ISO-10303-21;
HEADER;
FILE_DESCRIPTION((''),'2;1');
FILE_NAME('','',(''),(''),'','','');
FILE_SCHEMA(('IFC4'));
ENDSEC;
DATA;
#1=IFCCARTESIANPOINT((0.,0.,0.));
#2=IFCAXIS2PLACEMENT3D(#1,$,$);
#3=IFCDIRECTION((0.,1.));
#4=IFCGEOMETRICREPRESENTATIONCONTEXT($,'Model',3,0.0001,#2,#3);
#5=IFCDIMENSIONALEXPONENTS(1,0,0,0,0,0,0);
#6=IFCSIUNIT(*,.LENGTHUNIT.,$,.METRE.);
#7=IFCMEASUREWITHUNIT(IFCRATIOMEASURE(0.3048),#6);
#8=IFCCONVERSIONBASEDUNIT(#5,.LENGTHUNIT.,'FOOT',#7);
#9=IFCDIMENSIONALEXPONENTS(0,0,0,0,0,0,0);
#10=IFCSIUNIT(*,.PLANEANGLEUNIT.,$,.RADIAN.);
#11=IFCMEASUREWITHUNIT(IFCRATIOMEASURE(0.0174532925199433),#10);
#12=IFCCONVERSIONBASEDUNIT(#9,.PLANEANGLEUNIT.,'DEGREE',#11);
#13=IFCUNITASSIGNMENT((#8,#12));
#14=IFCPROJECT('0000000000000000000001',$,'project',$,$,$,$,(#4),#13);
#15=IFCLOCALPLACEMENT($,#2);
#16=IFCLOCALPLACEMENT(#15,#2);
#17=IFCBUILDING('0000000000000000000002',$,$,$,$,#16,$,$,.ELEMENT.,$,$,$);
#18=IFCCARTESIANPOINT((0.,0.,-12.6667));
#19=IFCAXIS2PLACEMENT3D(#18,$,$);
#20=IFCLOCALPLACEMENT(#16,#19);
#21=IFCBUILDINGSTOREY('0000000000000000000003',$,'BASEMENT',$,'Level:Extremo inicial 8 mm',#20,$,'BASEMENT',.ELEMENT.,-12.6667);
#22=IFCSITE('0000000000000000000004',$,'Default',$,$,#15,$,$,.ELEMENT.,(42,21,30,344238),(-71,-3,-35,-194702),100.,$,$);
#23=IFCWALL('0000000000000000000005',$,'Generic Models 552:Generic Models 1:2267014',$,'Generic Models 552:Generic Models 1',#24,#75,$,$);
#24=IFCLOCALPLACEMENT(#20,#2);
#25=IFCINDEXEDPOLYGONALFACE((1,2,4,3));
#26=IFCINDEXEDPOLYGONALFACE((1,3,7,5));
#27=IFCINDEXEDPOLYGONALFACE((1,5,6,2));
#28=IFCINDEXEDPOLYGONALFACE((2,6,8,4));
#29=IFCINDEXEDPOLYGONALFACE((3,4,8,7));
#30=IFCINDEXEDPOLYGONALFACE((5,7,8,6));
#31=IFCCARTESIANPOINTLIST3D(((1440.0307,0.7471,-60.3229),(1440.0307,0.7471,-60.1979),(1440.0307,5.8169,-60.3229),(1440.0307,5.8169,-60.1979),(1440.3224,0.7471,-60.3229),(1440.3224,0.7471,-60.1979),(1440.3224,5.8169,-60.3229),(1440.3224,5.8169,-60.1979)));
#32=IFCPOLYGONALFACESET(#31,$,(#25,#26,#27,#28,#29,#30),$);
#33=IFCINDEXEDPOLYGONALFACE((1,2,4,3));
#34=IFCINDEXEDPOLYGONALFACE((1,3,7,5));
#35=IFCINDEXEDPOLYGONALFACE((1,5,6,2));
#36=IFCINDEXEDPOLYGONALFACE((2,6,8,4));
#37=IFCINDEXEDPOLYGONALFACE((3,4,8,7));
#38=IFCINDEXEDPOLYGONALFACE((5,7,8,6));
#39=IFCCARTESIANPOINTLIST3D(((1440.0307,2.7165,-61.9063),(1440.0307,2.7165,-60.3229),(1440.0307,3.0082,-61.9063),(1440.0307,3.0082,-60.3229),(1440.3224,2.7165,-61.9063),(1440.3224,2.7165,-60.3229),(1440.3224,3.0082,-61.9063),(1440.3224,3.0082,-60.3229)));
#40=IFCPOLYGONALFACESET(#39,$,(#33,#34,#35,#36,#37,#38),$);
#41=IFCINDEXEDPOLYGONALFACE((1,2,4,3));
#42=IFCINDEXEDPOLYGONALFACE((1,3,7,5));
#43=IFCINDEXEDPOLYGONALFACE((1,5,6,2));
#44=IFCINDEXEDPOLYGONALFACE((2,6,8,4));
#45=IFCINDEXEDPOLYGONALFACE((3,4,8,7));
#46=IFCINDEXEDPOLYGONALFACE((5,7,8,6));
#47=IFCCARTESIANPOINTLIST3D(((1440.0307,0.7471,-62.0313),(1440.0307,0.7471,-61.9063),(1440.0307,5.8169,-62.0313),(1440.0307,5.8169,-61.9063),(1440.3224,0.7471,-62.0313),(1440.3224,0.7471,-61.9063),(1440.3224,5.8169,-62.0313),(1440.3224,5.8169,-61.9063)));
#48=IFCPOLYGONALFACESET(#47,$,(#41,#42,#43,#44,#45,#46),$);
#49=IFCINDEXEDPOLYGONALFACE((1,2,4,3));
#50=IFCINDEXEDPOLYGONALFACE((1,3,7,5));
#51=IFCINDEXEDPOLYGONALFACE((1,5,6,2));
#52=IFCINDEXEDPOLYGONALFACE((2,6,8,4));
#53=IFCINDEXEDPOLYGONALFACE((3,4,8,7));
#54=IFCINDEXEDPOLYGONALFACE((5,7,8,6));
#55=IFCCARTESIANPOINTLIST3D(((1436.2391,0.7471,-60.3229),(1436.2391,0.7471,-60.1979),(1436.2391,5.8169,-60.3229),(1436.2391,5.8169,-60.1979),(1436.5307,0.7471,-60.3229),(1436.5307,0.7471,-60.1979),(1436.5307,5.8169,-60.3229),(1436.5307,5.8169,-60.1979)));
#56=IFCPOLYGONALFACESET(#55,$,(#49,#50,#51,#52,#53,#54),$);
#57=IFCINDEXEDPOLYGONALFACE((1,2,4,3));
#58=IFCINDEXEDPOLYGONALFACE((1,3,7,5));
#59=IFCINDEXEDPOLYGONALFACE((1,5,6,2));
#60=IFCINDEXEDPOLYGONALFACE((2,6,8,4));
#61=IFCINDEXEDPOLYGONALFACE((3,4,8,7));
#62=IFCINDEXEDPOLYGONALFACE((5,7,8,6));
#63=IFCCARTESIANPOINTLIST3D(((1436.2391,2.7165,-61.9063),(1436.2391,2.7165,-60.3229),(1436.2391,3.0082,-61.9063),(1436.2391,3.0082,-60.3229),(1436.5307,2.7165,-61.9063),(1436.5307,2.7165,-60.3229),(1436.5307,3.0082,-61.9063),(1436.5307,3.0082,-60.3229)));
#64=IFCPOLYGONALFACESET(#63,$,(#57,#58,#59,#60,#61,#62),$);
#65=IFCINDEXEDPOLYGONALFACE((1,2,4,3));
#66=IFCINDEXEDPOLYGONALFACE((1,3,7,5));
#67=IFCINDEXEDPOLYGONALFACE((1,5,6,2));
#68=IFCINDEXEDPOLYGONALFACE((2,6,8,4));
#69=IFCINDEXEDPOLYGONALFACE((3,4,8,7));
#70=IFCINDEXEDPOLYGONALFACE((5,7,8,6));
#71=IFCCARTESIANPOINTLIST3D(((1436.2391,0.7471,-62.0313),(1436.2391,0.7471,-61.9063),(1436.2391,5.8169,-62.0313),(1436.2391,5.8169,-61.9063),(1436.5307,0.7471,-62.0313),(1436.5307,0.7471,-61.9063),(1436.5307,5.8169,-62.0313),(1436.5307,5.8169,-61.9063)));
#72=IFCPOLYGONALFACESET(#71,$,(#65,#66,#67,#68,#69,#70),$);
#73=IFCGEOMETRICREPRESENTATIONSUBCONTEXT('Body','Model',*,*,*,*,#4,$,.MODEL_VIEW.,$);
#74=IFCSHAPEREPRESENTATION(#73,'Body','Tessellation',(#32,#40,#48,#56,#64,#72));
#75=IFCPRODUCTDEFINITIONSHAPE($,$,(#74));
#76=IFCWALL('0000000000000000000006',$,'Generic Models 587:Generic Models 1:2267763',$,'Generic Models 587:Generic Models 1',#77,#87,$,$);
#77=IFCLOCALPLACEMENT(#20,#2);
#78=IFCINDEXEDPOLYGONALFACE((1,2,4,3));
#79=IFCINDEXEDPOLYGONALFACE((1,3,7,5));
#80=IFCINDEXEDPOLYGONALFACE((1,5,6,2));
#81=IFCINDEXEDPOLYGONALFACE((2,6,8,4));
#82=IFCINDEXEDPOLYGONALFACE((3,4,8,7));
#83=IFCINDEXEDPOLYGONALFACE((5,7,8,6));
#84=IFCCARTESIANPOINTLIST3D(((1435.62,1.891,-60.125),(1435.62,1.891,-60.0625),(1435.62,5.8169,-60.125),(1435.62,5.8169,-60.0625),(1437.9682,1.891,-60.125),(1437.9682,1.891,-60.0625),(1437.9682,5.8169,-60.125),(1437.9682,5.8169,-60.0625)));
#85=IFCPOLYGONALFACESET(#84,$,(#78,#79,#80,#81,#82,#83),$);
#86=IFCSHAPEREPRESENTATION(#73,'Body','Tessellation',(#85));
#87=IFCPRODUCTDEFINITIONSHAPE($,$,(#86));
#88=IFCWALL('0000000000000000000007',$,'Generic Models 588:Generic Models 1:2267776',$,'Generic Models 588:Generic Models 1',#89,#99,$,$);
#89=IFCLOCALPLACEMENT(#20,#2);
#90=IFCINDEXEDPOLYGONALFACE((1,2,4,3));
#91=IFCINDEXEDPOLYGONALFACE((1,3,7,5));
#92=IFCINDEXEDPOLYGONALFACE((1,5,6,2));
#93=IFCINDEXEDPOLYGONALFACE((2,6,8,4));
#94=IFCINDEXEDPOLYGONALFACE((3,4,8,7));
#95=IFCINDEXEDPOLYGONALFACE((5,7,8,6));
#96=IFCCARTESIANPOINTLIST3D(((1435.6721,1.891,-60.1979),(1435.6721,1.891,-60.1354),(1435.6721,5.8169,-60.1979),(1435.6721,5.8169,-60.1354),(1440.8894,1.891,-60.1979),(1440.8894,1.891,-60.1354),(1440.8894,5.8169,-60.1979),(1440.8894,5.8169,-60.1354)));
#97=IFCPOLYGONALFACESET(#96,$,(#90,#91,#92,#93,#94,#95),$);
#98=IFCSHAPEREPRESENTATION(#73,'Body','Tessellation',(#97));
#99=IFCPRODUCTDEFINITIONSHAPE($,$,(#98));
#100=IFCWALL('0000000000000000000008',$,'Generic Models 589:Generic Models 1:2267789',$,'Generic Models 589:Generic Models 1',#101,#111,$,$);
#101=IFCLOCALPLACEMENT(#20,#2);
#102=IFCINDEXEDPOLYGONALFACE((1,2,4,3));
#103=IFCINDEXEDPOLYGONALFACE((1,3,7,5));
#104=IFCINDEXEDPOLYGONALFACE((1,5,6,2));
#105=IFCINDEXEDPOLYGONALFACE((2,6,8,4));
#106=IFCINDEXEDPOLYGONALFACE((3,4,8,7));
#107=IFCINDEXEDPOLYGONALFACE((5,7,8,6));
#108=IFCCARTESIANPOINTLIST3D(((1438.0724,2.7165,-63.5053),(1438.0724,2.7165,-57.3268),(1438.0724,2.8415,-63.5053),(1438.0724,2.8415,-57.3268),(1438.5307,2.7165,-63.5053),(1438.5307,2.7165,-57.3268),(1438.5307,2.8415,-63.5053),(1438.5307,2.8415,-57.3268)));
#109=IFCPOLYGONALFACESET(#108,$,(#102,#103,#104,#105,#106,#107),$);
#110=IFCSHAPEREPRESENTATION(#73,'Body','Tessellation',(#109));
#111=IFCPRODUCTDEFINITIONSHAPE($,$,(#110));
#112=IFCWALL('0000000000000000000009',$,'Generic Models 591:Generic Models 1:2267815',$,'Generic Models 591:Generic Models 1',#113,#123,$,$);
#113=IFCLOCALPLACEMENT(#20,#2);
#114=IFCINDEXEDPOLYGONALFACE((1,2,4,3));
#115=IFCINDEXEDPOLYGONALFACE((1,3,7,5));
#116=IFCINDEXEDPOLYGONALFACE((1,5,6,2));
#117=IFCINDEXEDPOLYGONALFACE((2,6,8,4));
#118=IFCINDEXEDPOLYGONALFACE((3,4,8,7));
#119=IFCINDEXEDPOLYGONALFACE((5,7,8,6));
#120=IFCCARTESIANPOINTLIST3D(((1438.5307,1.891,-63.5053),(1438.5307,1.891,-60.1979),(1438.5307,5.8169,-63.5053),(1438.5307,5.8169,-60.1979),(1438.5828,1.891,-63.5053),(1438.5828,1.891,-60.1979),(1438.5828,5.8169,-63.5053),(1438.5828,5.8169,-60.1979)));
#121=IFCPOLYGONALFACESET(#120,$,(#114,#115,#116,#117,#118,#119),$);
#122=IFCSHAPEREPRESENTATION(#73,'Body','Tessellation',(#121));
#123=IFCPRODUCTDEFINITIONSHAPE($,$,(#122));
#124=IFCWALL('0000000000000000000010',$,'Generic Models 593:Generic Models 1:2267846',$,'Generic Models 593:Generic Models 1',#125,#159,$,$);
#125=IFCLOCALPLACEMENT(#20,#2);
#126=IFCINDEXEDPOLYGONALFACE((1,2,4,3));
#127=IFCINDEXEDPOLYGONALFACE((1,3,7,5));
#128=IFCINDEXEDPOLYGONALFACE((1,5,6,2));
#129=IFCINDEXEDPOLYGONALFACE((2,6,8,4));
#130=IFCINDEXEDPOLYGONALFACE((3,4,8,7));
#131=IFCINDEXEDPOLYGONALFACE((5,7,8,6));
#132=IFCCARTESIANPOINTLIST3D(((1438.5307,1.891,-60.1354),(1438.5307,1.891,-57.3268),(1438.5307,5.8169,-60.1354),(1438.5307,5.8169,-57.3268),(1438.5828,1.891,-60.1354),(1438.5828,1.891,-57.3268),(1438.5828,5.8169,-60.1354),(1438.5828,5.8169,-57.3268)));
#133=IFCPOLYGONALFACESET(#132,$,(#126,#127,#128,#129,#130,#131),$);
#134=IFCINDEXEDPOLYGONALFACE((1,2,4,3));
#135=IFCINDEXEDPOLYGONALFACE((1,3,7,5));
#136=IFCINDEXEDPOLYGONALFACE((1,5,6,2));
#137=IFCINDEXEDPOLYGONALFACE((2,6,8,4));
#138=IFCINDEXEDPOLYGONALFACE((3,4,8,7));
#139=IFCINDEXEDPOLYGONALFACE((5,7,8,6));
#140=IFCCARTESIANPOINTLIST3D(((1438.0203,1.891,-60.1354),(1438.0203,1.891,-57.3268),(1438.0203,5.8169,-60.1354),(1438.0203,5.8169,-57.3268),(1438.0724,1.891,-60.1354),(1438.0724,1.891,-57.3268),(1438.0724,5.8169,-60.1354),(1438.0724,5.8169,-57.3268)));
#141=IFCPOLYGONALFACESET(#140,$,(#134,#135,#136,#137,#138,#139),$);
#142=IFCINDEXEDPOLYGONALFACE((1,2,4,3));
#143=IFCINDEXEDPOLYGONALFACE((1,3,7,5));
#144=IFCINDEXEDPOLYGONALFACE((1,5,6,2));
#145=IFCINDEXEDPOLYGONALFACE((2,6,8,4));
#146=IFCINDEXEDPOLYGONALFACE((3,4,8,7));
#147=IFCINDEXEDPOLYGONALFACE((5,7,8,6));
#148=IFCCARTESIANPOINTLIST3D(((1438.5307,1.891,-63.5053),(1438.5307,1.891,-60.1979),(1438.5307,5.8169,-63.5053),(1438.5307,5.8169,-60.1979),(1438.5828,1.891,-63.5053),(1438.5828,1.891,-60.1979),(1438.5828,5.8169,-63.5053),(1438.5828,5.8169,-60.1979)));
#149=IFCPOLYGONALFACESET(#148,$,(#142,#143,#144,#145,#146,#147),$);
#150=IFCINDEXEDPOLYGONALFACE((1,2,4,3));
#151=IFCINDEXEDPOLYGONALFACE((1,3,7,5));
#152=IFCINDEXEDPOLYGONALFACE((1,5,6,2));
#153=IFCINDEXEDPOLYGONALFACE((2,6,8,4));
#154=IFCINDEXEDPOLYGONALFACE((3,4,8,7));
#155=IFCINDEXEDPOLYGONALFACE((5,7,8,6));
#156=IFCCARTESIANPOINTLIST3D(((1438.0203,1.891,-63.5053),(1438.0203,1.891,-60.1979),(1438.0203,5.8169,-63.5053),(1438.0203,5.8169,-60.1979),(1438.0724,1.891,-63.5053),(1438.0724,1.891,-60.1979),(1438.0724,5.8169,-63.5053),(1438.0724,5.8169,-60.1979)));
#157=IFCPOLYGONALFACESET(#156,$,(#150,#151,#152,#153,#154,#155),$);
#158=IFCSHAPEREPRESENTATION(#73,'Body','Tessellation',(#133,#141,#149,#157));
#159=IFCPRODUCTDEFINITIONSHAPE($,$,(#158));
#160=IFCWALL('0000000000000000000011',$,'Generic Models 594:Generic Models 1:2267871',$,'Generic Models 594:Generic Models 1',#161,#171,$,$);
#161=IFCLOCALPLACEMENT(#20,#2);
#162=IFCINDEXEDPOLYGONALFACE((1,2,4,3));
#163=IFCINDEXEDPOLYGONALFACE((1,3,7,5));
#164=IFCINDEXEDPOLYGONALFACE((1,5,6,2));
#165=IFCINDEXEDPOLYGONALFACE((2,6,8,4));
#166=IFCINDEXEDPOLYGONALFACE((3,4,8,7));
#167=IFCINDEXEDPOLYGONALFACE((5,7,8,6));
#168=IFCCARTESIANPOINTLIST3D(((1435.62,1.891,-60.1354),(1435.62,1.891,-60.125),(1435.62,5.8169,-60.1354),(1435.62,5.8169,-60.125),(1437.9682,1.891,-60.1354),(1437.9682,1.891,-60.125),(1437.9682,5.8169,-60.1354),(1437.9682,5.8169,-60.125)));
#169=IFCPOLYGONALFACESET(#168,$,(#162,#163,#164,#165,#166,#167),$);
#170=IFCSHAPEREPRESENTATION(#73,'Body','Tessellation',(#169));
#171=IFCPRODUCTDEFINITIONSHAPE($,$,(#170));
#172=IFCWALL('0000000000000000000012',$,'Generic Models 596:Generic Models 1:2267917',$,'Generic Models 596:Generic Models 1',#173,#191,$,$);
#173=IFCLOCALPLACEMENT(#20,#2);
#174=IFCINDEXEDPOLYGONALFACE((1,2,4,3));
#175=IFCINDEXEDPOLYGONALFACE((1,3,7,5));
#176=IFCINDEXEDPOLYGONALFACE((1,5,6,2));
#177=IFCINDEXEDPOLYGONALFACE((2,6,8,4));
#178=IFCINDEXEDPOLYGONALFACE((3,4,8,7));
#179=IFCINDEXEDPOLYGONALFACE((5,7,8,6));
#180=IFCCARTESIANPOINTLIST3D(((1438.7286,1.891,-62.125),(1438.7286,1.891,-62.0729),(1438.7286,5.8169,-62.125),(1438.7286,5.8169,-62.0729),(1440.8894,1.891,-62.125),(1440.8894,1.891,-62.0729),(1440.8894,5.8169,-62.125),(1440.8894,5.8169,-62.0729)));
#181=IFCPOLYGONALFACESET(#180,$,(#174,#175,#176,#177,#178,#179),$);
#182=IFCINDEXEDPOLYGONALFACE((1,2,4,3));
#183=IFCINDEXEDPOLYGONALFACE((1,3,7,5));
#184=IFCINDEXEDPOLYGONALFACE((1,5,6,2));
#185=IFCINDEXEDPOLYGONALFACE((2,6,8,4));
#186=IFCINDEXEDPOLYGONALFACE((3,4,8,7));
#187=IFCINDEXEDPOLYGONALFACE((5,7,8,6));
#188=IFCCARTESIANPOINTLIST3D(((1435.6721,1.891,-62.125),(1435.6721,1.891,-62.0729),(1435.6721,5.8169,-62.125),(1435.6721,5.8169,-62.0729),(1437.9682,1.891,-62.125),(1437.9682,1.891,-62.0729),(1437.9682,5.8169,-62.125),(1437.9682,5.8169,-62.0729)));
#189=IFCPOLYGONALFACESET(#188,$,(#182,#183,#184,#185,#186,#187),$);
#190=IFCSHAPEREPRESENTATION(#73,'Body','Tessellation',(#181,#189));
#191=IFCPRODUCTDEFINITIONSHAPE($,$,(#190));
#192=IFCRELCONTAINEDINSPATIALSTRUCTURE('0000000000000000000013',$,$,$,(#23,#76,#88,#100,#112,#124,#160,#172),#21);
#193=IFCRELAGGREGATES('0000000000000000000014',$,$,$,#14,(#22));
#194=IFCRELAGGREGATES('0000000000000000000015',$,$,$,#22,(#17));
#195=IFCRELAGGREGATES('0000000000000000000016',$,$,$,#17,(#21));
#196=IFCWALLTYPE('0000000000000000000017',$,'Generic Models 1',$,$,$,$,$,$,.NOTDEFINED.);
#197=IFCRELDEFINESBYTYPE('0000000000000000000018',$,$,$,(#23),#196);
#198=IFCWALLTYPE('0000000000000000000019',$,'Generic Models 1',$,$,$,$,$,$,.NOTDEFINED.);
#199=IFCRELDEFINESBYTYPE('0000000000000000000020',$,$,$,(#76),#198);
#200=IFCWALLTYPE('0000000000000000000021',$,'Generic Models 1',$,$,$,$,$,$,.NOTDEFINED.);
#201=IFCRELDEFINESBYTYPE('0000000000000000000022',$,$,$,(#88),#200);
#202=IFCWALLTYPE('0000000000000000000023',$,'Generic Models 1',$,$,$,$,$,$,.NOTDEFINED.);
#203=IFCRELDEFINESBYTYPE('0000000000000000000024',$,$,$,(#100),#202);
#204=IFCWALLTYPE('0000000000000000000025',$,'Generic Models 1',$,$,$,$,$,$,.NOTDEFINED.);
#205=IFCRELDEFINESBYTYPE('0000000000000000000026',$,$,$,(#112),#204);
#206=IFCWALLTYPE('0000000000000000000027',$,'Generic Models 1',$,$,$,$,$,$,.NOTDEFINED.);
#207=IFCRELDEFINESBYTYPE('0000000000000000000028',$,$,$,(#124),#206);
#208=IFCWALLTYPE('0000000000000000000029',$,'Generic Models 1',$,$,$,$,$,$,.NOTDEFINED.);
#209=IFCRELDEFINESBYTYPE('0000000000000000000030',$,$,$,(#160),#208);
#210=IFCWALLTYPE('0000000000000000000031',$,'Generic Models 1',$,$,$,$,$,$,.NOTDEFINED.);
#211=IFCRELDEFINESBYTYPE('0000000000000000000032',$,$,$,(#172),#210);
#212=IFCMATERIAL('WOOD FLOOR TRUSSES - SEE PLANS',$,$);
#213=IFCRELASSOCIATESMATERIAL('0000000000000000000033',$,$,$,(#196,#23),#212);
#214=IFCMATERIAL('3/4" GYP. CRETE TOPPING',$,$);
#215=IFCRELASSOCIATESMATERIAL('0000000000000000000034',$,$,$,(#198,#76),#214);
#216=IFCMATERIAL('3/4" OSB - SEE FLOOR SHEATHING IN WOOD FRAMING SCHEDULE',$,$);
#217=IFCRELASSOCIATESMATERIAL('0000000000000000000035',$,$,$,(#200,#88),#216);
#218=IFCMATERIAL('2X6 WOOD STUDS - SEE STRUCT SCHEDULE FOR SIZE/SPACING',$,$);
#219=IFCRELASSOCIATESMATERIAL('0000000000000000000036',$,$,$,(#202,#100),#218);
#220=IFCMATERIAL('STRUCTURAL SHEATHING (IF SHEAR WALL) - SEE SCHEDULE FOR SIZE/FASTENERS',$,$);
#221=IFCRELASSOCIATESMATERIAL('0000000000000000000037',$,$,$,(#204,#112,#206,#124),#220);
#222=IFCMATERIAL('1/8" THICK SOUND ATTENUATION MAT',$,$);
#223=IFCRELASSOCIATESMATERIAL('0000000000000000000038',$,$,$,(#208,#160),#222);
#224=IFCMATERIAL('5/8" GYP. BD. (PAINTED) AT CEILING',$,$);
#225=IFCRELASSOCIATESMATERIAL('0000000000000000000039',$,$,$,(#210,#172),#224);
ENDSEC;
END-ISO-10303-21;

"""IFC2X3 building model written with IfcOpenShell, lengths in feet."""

from ifc_helpers import new_model, entity, si_unit, converted_unit, direction, frame, frame_2d, origin, origin_2d_with_axis, place, context, subcontext, project, spatial, rectangle, extrude, material, type_object, element, save


model = new_model("IFC2X3")

# Units and contexts
model_context = context("Model", 3, precision=0.0001, world=origin(), true_north=direction((0.0, 1.0)))
body_context = subcontext(model_context, "Body", "Model", "MODEL_VIEW")
ifc_project = project(units=[converted_unit("LENGTHUNIT", "FOOT", entity("IfcRatioMeasure", 0.3048), si_unit("LENGTHUNIT", "METRE"), dimensions=[1, 0, 0, 0, 0, 0, 0]), converted_unit("PLANEANGLEUNIT", "DEGREE", entity("IfcRatioMeasure", 0.0174532925199433), si_unit("PLANEANGLEUNIT", "RADIAN"), dimensions=[0, 0, 0, 0, 0, 0, 0])], contexts=[model_context])

# Site, building, storey
site_placement = place(None, origin())
site = spatial("IfcSite", under=ifc_project, at=site_placement, Name="Default", CompositionType="ELEMENT", RefLatitude=(42, 21, 30, 344238), RefLongitude=(-71, -3, -35, -194702), RefElevation=100.0)
building_placement = place(site_placement, origin())
building = spatial("IfcBuilding", under=site, at=building_placement, CompositionType="ELEMENT")
storey_placement = place(building_placement, frame((0.0, 0.0, -12.6667)))
storey = spatial("IfcBuildingStorey", under=building, at=storey_placement, Name="BASEMENT", ObjectType="Level:Extremo inicial 8 mm", LongName="BASEMENT", CompositionType="ELEMENT", Elevation=-12.6667)

# Walls
ifc_material_1 = material(Name="WOOD FLOOR TRUSSES - SEE PLANS")
wall_type_1 = type_object("IfcWallType", Name="Generic Models 1", PredefinedType="NOTDEFINED", material=ifc_material_1)
wall_1_placement = place(storey_placement, frame((1436.2391, 0.7471, -62.0313), z_axis=(0.0, 0.0, 1.0), x_axis=(0.0, 1.0, 0.0)))
element("IfcWall", 1, at=wall_1_placement, inside=storey, type_object=wall_type_1, material=ifc_material_1, Name="Generic Models 552:Generic Models 1:2267014", ObjectType="Generic Models 552:Generic Models 1", context=body_context, shape_type="SweptSolid", body=[
    extrude(rectangle(XDim=5.0697, YDim=0.2917, at=frame_2d((0.0, 0.0), x_axis=(1.0, 0.0))), frame((2.5349, -3.9375, 1.7083)), (0.0, 0.0, 1.0), 0.125),
    extrude(rectangle(XDim=0.2917, YDim=0.2917, at=frame_2d((0.0, 0.0), x_axis=(1.0, 0.0))), frame((2.1152, -3.9375, 0.125)), (0.0, 0.0, 1.0), 1.5833),
    extrude(rectangle(XDim=5.0697, YDim=0.2917, at=frame_2d((0.0, 0.0), x_axis=(1.0, 0.0))), frame((2.5349, -3.9375, 0.0)), (0.0, 0.0, 1.0), 0.125),
    extrude(rectangle(XDim=5.0697, YDim=0.2917, at=frame_2d((0.0, 0.0), x_axis=(1.0, 0.0))), frame((2.5349, -0.1458, 1.7083)), (0.0, 0.0, 1.0), 0.125),
    extrude(rectangle(XDim=0.2917, YDim=0.2917, at=frame_2d((0.0, 0.0), x_axis=(1.0, 0.0))), frame((2.1152, -0.1458, 0.125)), (0.0, 0.0, 1.0), 1.5833),
    extrude(rectangle(XDim=5.0697, YDim=0.2917, at=frame_2d((0.0, 0.0), x_axis=(1.0, 0.0))), frame((2.5349, -0.1458, 0.0)), (0.0, 0.0, 1.0), 0.125),
])
ifc_material_2 = material(Name="3/4\" GYP. CRETE TOPPING")
wall_type_2 = type_object("IfcWallType", Name="Generic Models 1", PredefinedType="NOTDEFINED", material=ifc_material_2)
wall_2_placement = place(storey_placement, frame((1435.62, 1.891, -60.125), z_axis=(0.0, 0.0, 1.0), x_axis=(0.0, 1.0, 0.0)))
element("IfcWall", 2, at=wall_2_placement, inside=storey, type_object=wall_type_2, material=ifc_material_2, Name="Generic Models 587:Generic Models 1:2267763", ObjectType="Generic Models 587:Generic Models 1", context=body_context, shape_type="SweptSolid", body=[
    extrude(rectangle(XDim=3.9258, YDim=2.3483, at=frame_2d((0.0, 0.0), x_axis=(1.0, 0.0))), frame((1.9629, -1.1741, 0.0)), (0.0, 0.0, 1.0), 0.0625),
])
ifc_material_3 = material(Name="3/4\" OSB - SEE FLOOR SHEATHING IN WOOD FRAMING SCHEDULE")
wall_type_3 = type_object("IfcWallType", Name="Generic Models 1", PredefinedType="NOTDEFINED", material=ifc_material_3)
wall_3_placement = place(storey_placement, frame((1435.6721, 1.891, -60.1979)))
element("IfcWall", 3, at=wall_3_placement, inside=storey, type_object=wall_type_3, material=ifc_material_3, Name="Generic Models 588:Generic Models 1:2267776", ObjectType="Generic Models 588:Generic Models 1", context=body_context, shape_type="SweptSolid", body=[
    extrude(rectangle(XDim=3.9258, YDim=5.2173, at=frame_2d((0.0, 0.0), x_axis=(1.0, 0.0))), frame((2.6087, 1.9629, 0.0), z_axis=(0.0, 0.0, 1.0), x_axis=(0.0, 1.0, 0.0)), (0.0, 0.0, 1.0), 0.0625),
])
ifc_material_4 = material(Name="2X6 WOOD STUDS - SEE STRUCT SCHEDULE FOR SIZE/SPACING")
wall_type_4 = type_object("IfcWallType", Name="Generic Models 1", PredefinedType="NOTDEFINED", material=ifc_material_4)
wall_4_placement = place(storey_placement, frame((1438.0724, 2.7165, -63.5053)))
element("IfcWall", 4, at=wall_4_placement, inside=storey, type_object=wall_type_4, material=ifc_material_4, Name="Generic Models 589:Generic Models 1:2267789", ObjectType="Generic Models 589:Generic Models 1", context=body_context, shape_type="SweptSolid", body=[
    extrude(rectangle(XDim=0.125, YDim=0.4583, at=frame_2d((0.0, 0.0), x_axis=(1.0, 0.0))), frame((0.2292, 0.0625, 0.0), z_axis=(0.0, 0.0, 1.0), x_axis=(0.0, 1.0, 0.0)), (0.0, 0.0, 1.0), 6.1785),
])
ifc_material_5 = material(Name="STRUCTURAL SHEATHING (IF SHEAR WALL) - SEE SCHEDULE FOR SIZE/FASTENERS")
wall_type_5 = type_object("IfcWallType", Name="Generic Models 1", PredefinedType="NOTDEFINED", material=ifc_material_5)
wall_5_placement = place(storey_placement, frame((1438.5307, 1.891, -63.5053), z_axis=(0.0, 0.0, 1.0), x_axis=(0.0, 1.0, 0.0)))
element("IfcWall", 5, at=wall_5_placement, inside=storey, type_object=wall_type_5, material=ifc_material_5, Name="Generic Models 591:Generic Models 1:2267815", ObjectType="Generic Models 591:Generic Models 1", context=body_context, shape_type="SweptSolid", body=[
    extrude(rectangle(XDim=3.9258, YDim=0.0521, at=frame_2d((0.0, 0.0), x_axis=(1.0, 0.0))), frame((1.9629, -0.026, 0.0)), (0.0, 0.0, 1.0), 3.3074),
])
wall_type_6 = type_object("IfcWallType", Name="Generic Models 1", PredefinedType="NOTDEFINED", material=ifc_material_5)
wall_6_placement = place(storey_placement, frame((1438.0203, 1.891, -63.5053), z_axis=(0.0, 0.0, 1.0), x_axis=(0.0, 1.0, 0.0)))
element("IfcWall", 6, at=wall_6_placement, inside=storey, type_object=wall_type_6, material=ifc_material_5, Name="Generic Models 593:Generic Models 1:2267846", ObjectType="Generic Models 593:Generic Models 1", context=body_context, shape_type="SweptSolid", body=[
    extrude(rectangle(XDim=3.9258, YDim=0.0521, at=frame_2d((0.0, 0.0), x_axis=(1.0, 0.0))), frame((1.9629, -0.5365, 3.3699)), (0.0, 0.0, 1.0), 2.8086),
    extrude(rectangle(XDim=3.9258, YDim=0.0521, at=frame_2d((0.0, 0.0), x_axis=(1.0, 0.0))), frame((1.9629, -0.026, 3.3699)), (0.0, 0.0, 1.0), 2.8086),
    extrude(rectangle(XDim=3.9258, YDim=0.0521, at=frame_2d((0.0, 0.0), x_axis=(1.0, 0.0))), frame((1.9629, -0.5365, 0.0)), (0.0, 0.0, 1.0), 3.3074),
    extrude(rectangle(XDim=3.9258, YDim=0.0521, at=frame_2d((0.0, 0.0), x_axis=(1.0, 0.0))), frame((1.9629, -0.026, 0.0)), (0.0, 0.0, 1.0), 3.3074),
])
ifc_material_6 = material(Name="1/8\" THICK SOUND ATTENUATION MAT")
wall_type_7 = type_object("IfcWallType", Name="Generic Models 1", PredefinedType="NOTDEFINED", material=ifc_material_6)
wall_7_placement = place(storey_placement, frame((1435.62, 1.891, -60.1354), z_axis=(0.0, 0.0, 1.0), x_axis=(0.0, 1.0, 0.0)))
element("IfcWall", 7, at=wall_7_placement, inside=storey, type_object=wall_type_7, material=ifc_material_6, Name="Generic Models 594:Generic Models 1:2267871", ObjectType="Generic Models 594:Generic Models 1", context=body_context, shape_type="SweptSolid", body=[
    extrude(rectangle(XDim=3.9258, YDim=2.3483, at=frame_2d((0.0, 0.0), x_axis=(1.0, 0.0))), frame((1.9629, -1.1741, 0.0)), (0.0, 0.0, 1.0), 0.0104),
])
ifc_material_7 = material(Name="5/8\" GYP. BD. (PAINTED) AT CEILING")
wall_type_8 = type_object("IfcWallType", Name="Generic Models 1", PredefinedType="NOTDEFINED", material=ifc_material_7)
wall_8_placement = place(storey_placement, frame((1435.6721, 1.891, -62.125)))
element("IfcWall", 8, at=wall_8_placement, inside=storey, type_object=wall_type_8, material=ifc_material_7, Name="Generic Models 596:Generic Models 1:2267917", ObjectType="Generic Models 596:Generic Models 1", context=body_context, shape_type="SweptSolid", body=[
    extrude(rectangle(XDim=3.9258, YDim=2.1608, at=origin_2d_with_axis()), frame((4.137, 1.9629, 0.0), z_axis=(0.0, 0.0, 1.0), x_axis=(0.0, 1.0, 0.0)), (0.0, 0.0, 1.0), 0.0521),
    extrude(rectangle(XDim=3.9258, YDim=2.2962, at=frame_2d((0.0, 0.0), x_axis=(1.0, 0.0))), frame((1.1481, 1.9629, 0.0), z_axis=(0.0, 0.0, 1.0), x_axis=(0.0, 1.0, 0.0)), (0.0, 0.0, 1.0), 0.0521),
])

save(model, "model.ifc")
